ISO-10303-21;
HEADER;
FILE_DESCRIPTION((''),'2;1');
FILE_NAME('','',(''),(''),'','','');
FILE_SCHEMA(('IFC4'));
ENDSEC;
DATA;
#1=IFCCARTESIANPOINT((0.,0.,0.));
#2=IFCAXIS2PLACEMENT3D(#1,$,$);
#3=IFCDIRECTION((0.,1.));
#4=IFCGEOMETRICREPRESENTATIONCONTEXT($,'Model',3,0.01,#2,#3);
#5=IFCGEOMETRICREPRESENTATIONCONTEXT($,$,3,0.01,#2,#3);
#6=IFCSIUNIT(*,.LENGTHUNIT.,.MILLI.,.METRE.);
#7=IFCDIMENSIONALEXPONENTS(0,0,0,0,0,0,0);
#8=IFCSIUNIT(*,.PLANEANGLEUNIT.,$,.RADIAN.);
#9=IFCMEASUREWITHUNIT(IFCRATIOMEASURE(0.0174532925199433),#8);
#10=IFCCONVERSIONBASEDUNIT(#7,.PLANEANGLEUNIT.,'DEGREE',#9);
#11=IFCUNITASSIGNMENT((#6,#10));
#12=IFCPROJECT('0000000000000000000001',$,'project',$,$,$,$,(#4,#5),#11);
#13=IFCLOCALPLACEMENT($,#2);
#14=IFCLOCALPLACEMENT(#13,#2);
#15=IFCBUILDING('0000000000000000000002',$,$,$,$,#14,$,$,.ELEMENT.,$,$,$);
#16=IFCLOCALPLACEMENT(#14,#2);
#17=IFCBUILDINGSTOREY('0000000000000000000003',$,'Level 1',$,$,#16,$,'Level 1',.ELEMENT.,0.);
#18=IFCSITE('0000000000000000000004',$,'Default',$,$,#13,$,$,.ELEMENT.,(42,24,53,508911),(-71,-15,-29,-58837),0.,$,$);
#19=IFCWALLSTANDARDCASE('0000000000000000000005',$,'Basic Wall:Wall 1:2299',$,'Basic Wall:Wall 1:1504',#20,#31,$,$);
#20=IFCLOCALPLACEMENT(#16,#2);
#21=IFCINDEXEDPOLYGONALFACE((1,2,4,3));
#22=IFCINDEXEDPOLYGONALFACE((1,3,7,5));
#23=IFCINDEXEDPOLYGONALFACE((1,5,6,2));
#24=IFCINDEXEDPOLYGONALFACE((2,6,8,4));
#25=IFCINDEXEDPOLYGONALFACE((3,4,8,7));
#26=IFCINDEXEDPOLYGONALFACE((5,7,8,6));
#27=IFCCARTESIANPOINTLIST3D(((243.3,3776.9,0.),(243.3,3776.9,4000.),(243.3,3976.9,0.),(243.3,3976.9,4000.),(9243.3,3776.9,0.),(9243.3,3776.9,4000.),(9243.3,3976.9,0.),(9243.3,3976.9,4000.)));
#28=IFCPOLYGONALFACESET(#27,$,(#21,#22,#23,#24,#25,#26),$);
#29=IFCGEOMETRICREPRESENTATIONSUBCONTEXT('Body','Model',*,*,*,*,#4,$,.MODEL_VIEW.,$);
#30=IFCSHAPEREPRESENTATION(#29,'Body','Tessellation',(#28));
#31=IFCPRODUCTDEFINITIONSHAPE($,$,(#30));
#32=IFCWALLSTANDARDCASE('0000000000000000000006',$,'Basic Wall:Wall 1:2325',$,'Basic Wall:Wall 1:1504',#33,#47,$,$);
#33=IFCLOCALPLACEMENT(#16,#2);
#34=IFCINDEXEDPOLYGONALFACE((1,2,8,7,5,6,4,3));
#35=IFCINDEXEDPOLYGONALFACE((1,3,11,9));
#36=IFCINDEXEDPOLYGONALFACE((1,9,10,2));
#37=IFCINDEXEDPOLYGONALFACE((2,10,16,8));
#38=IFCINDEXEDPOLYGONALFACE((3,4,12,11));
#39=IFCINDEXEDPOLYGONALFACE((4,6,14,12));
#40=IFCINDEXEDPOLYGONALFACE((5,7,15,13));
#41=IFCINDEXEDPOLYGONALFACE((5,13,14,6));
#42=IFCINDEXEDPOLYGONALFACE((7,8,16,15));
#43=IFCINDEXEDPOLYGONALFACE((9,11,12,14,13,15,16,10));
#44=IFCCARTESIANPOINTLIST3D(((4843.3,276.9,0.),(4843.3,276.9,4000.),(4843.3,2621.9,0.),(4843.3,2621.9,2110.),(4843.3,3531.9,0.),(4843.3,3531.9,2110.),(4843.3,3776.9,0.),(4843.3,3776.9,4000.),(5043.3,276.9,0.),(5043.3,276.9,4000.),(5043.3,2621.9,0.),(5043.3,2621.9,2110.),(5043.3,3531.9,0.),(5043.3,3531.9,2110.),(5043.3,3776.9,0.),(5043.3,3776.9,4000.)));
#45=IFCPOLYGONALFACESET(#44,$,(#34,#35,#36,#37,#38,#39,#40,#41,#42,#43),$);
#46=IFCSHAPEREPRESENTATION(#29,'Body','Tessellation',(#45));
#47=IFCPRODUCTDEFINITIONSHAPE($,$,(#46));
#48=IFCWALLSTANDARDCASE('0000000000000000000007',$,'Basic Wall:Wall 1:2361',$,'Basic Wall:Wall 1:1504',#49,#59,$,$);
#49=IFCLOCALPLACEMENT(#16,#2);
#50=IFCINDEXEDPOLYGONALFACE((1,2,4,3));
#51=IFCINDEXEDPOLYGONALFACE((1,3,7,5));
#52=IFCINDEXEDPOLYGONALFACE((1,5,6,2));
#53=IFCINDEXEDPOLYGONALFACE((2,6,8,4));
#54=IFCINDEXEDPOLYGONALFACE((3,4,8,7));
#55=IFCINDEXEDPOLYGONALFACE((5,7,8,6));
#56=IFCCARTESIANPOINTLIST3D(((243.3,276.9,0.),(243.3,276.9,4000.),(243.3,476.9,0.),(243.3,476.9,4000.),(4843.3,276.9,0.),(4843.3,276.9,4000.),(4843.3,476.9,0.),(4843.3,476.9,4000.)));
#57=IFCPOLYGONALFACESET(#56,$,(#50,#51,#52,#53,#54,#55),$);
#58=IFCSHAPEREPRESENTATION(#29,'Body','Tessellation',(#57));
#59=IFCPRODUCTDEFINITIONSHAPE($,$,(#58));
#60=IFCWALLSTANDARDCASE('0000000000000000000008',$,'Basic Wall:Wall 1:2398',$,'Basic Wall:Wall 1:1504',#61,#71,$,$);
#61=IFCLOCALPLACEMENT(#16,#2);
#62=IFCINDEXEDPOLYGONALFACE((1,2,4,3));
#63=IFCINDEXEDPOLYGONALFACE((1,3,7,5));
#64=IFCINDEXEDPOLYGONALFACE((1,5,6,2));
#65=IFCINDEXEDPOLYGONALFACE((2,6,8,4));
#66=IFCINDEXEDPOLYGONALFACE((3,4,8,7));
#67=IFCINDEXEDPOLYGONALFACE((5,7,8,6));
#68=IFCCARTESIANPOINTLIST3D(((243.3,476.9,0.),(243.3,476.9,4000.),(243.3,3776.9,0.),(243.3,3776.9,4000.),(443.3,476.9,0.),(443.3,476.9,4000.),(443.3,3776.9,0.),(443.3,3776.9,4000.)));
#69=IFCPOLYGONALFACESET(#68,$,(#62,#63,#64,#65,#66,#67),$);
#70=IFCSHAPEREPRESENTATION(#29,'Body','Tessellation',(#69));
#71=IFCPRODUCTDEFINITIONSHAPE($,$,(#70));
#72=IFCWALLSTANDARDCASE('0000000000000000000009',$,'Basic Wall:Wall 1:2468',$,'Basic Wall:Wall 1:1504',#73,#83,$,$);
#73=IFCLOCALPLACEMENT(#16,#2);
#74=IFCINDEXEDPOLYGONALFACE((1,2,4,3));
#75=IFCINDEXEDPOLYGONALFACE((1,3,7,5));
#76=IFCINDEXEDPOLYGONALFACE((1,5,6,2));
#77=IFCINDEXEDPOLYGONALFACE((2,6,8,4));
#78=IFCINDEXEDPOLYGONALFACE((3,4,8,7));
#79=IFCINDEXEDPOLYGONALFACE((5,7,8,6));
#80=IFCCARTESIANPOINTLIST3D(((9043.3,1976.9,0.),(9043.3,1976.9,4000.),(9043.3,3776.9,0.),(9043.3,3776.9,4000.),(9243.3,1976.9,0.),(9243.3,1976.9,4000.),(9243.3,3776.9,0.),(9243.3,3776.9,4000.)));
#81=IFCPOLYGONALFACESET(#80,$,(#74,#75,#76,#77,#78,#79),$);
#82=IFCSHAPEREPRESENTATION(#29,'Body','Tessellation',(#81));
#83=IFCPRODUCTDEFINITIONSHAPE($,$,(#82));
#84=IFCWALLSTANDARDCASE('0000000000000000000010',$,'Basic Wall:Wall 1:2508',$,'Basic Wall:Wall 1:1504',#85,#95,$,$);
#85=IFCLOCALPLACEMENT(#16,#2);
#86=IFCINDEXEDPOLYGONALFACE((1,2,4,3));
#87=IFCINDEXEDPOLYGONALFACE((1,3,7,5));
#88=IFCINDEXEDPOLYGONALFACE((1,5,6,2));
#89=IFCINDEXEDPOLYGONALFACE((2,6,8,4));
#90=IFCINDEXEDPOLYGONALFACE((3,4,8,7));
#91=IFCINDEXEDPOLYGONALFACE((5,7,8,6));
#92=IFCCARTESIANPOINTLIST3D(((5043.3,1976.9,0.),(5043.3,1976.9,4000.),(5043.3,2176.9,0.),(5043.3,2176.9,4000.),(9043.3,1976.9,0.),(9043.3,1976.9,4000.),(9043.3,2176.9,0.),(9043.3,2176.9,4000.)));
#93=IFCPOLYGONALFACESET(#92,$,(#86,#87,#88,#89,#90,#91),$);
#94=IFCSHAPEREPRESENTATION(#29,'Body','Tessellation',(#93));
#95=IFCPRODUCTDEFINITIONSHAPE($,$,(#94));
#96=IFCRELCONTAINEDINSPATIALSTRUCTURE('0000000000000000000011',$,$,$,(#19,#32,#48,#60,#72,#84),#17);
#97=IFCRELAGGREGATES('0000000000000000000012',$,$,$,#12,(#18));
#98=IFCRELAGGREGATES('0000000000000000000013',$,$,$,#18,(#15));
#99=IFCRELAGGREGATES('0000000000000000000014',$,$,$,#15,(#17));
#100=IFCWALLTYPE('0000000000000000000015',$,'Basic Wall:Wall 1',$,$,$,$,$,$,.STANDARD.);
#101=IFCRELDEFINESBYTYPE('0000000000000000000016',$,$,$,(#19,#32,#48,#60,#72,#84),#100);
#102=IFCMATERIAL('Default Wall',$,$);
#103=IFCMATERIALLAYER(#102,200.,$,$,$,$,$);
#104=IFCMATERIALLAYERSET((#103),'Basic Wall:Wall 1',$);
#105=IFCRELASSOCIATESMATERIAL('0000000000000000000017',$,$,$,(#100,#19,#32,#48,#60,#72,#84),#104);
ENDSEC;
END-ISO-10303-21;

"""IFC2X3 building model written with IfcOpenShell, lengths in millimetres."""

from ifc_helpers import new_model, entity, si_unit, converted_unit, direction, frame, frame_2d, origin, place, context, subcontext, project, spatial, rectangle, extrude, material, layer, layer_set, layer_usage, type_object, element, save


model = new_model("IFC2X3")

# Units and contexts
model_context = context("Model", 3, precision=0.01, world=origin(), true_north=direction((0.0, 1.0)))
context_of_model = context(None, 3, precision=0.01, world=origin(), true_north=direction((0.0, 1.0)))
body_context = subcontext(model_context, "Body", "Model", "MODEL_VIEW")
ifc_project = project(units=[si_unit("LENGTHUNIT", "METRE", prefix="MILLI"), converted_unit("PLANEANGLEUNIT", "DEGREE", entity("IfcRatioMeasure", 0.0174532925199433), si_unit("PLANEANGLEUNIT", "RADIAN"), dimensions=[0, 0, 0, 0, 0, 0, 0])], contexts=[model_context, context_of_model])

# Site, building, storey
site_placement = place(None, origin())
site = spatial("IfcSite", under=ifc_project, at=site_placement, Name="Default", CompositionType="ELEMENT", RefLatitude=(42, 24, 53, 508911), RefLongitude=(-71, -15, -29, -58837), RefElevation=0.0)
building_placement = place(site_placement, origin())
building = spatial("IfcBuilding", under=site, at=building_placement, CompositionType="ELEMENT")
storey_placement = place(building_placement, origin())
storey = spatial("IfcBuildingStorey", under=building, at=storey_placement, Name="Level 1", LongName="Level 1", CompositionType="ELEMENT", Elevation=0.0)

# Wall
ifc_material = material(Name="Default Wall")
ifc_layer = layer(ifc_material, 200.0)
ifc_layer_set = layer_set([ifc_layer], Name="Basic Wall:Wall 1")
ifc_layer_usage_1 = layer_usage(ifc_layer_set, "AXIS2", "NEGATIVE", 100.0)
wall_type = type_object("IfcWallType", Name="Basic Wall:Wall 1", PredefinedType="STANDARD", material=ifc_layer_set)
wall_1_placement = place(storey_placement, frame((243.3, 3876.9, 0.0)))
element("IfcWallStandardCase", 1, at=wall_1_placement, inside=storey, type_object=wall_type, material=ifc_layer_usage_1, Name="Basic Wall:Wall 1:2299", ObjectType="Basic Wall:Wall 1:1504", context=body_context, shape_type="SweptSolid", body=[
    extrude(rectangle(XDim=9000.0, YDim=200.0, at=frame_2d((4500.0, 0.0), x_axis=(-1.0, 0.0))), origin(), (0.0, 0.0, 1.0), 4000.0),
])

# Wall, opening
ifc_layer_usage_2 = layer_usage(ifc_layer_set, "AXIS2", "NEGATIVE", 100.0)
wall_2_placement = place(storey_placement, frame((4943.3, 3776.9, 0.0), z_axis=(0.0, 0.0, 1.0), x_axis=(0.0, -1.0, 0.0)))
wall_2 = element("IfcWallStandardCase", 2, at=wall_2_placement, inside=storey, type_object=wall_type, material=ifc_layer_usage_2, Name="Basic Wall:Wall 1:2325", ObjectType="Basic Wall:Wall 1:1504", context=body_context, shape_type="SweptSolid", body=[
    extrude(rectangle(XDim=3500.0, YDim=200.0, at=frame_2d((1750.0, 0.0), x_axis=(-1.0, 0.0))), origin(), (0.0, 0.0, 1.0), 4000.0),
])
opening_placement = place(wall_2_placement, frame((245.0, -100.0, 0.0)))
element("IfcOpeningElement", 3, at=opening_placement, cuts=wall_2, ObjectType="Opening", context=body_context, shape_type="SweptSolid", body=[
    extrude(rectangle(XDim=2110.0, YDim=910.0, at=frame_2d((1055.0, 455.0), x_axis=(-1.0, 0.0))), frame((0.0, 0.0, 0.0), z_axis=(0.0, 1.0, 0.0), x_axis=(0.0, 0.0, 1.0)), (0.0, 0.0, 1.0), 200.0),
])

# Walls
ifc_layer_usage_3 = layer_usage(ifc_layer_set, "AXIS2", "NEGATIVE", 100.0)
wall_3_placement = place(storey_placement, frame((4843.3, 376.9, 0.0), z_axis=(0.0, 0.0, 1.0), x_axis=(-1.0, 0.0, 0.0)))
element("IfcWallStandardCase", 4, at=wall_3_placement, inside=storey, type_object=wall_type, material=ifc_layer_usage_3, Name="Basic Wall:Wall 1:2361", ObjectType="Basic Wall:Wall 1:1504", context=body_context, shape_type="SweptSolid", body=[
    extrude(rectangle(XDim=4600.0, YDim=200.0, at=frame_2d((2300.0, 0.0), x_axis=(-1.0, 0.0))), origin(), (0.0, 0.0, 1.0), 4000.0),
])
ifc_layer_usage_4 = layer_usage(ifc_layer_set, "AXIS2", "NEGATIVE", 100.0)
wall_4_placement = place(storey_placement, frame((343.3, 476.9, 0.0), z_axis=(0.0, 0.0, 1.0), x_axis=(0.0, 1.0, 0.0)))
element("IfcWallStandardCase", 5, at=wall_4_placement, inside=storey, type_object=wall_type, material=ifc_layer_usage_4, Name="Basic Wall:Wall 1:2398", ObjectType="Basic Wall:Wall 1:1504", context=body_context, shape_type="SweptSolid", body=[
    extrude(rectangle(XDim=3300.0, YDim=200.0, at=frame_2d((1650.0, 0.0), x_axis=(-1.0, 0.0))), origin(), (0.0, 0.0, 1.0), 4000.0),
])
ifc_layer_usage_5 = layer_usage(ifc_layer_set, "AXIS2", "NEGATIVE", 100.0)
wall_5_placement = place(storey_placement, frame((9143.3, 3776.9, 0.0), z_axis=(0.0, 0.0, 1.0), x_axis=(0.0, -1.0, 0.0)))
element("IfcWallStandardCase", 6, at=wall_5_placement, inside=storey, type_object=wall_type, material=ifc_layer_usage_5, Name="Basic Wall:Wall 1:2468", ObjectType="Basic Wall:Wall 1:1504", context=body_context, shape_type="SweptSolid", body=[
    extrude(rectangle(XDim=1800.0, YDim=200.0, at=frame_2d((900.0, 0.0), x_axis=(-1.0, 0.0))), origin(), (0.0, 0.0, 1.0), 4000.0),
])
ifc_layer_usage_6 = layer_usage(ifc_layer_set, "AXIS2", "NEGATIVE", 100.0)
wall_6_placement = place(storey_placement, frame((9043.3, 2076.9, 0.0), z_axis=(0.0, 0.0, 1.0), x_axis=(-1.0, 0.0, 0.0)))
element("IfcWallStandardCase", 7, at=wall_6_placement, inside=storey, type_object=wall_type, material=ifc_layer_usage_6, Name="Basic Wall:Wall 1:2508", ObjectType="Basic Wall:Wall 1:1504", context=body_context, shape_type="SweptSolid", body=[
    extrude(rectangle(XDim=4000.0, YDim=200.0, at=frame_2d((2000.0, 0.0), x_axis=(-1.0, 0.0))), origin(), (0.0, 0.0, 1.0), 4000.0),
])

save(model, "model.ifc")
